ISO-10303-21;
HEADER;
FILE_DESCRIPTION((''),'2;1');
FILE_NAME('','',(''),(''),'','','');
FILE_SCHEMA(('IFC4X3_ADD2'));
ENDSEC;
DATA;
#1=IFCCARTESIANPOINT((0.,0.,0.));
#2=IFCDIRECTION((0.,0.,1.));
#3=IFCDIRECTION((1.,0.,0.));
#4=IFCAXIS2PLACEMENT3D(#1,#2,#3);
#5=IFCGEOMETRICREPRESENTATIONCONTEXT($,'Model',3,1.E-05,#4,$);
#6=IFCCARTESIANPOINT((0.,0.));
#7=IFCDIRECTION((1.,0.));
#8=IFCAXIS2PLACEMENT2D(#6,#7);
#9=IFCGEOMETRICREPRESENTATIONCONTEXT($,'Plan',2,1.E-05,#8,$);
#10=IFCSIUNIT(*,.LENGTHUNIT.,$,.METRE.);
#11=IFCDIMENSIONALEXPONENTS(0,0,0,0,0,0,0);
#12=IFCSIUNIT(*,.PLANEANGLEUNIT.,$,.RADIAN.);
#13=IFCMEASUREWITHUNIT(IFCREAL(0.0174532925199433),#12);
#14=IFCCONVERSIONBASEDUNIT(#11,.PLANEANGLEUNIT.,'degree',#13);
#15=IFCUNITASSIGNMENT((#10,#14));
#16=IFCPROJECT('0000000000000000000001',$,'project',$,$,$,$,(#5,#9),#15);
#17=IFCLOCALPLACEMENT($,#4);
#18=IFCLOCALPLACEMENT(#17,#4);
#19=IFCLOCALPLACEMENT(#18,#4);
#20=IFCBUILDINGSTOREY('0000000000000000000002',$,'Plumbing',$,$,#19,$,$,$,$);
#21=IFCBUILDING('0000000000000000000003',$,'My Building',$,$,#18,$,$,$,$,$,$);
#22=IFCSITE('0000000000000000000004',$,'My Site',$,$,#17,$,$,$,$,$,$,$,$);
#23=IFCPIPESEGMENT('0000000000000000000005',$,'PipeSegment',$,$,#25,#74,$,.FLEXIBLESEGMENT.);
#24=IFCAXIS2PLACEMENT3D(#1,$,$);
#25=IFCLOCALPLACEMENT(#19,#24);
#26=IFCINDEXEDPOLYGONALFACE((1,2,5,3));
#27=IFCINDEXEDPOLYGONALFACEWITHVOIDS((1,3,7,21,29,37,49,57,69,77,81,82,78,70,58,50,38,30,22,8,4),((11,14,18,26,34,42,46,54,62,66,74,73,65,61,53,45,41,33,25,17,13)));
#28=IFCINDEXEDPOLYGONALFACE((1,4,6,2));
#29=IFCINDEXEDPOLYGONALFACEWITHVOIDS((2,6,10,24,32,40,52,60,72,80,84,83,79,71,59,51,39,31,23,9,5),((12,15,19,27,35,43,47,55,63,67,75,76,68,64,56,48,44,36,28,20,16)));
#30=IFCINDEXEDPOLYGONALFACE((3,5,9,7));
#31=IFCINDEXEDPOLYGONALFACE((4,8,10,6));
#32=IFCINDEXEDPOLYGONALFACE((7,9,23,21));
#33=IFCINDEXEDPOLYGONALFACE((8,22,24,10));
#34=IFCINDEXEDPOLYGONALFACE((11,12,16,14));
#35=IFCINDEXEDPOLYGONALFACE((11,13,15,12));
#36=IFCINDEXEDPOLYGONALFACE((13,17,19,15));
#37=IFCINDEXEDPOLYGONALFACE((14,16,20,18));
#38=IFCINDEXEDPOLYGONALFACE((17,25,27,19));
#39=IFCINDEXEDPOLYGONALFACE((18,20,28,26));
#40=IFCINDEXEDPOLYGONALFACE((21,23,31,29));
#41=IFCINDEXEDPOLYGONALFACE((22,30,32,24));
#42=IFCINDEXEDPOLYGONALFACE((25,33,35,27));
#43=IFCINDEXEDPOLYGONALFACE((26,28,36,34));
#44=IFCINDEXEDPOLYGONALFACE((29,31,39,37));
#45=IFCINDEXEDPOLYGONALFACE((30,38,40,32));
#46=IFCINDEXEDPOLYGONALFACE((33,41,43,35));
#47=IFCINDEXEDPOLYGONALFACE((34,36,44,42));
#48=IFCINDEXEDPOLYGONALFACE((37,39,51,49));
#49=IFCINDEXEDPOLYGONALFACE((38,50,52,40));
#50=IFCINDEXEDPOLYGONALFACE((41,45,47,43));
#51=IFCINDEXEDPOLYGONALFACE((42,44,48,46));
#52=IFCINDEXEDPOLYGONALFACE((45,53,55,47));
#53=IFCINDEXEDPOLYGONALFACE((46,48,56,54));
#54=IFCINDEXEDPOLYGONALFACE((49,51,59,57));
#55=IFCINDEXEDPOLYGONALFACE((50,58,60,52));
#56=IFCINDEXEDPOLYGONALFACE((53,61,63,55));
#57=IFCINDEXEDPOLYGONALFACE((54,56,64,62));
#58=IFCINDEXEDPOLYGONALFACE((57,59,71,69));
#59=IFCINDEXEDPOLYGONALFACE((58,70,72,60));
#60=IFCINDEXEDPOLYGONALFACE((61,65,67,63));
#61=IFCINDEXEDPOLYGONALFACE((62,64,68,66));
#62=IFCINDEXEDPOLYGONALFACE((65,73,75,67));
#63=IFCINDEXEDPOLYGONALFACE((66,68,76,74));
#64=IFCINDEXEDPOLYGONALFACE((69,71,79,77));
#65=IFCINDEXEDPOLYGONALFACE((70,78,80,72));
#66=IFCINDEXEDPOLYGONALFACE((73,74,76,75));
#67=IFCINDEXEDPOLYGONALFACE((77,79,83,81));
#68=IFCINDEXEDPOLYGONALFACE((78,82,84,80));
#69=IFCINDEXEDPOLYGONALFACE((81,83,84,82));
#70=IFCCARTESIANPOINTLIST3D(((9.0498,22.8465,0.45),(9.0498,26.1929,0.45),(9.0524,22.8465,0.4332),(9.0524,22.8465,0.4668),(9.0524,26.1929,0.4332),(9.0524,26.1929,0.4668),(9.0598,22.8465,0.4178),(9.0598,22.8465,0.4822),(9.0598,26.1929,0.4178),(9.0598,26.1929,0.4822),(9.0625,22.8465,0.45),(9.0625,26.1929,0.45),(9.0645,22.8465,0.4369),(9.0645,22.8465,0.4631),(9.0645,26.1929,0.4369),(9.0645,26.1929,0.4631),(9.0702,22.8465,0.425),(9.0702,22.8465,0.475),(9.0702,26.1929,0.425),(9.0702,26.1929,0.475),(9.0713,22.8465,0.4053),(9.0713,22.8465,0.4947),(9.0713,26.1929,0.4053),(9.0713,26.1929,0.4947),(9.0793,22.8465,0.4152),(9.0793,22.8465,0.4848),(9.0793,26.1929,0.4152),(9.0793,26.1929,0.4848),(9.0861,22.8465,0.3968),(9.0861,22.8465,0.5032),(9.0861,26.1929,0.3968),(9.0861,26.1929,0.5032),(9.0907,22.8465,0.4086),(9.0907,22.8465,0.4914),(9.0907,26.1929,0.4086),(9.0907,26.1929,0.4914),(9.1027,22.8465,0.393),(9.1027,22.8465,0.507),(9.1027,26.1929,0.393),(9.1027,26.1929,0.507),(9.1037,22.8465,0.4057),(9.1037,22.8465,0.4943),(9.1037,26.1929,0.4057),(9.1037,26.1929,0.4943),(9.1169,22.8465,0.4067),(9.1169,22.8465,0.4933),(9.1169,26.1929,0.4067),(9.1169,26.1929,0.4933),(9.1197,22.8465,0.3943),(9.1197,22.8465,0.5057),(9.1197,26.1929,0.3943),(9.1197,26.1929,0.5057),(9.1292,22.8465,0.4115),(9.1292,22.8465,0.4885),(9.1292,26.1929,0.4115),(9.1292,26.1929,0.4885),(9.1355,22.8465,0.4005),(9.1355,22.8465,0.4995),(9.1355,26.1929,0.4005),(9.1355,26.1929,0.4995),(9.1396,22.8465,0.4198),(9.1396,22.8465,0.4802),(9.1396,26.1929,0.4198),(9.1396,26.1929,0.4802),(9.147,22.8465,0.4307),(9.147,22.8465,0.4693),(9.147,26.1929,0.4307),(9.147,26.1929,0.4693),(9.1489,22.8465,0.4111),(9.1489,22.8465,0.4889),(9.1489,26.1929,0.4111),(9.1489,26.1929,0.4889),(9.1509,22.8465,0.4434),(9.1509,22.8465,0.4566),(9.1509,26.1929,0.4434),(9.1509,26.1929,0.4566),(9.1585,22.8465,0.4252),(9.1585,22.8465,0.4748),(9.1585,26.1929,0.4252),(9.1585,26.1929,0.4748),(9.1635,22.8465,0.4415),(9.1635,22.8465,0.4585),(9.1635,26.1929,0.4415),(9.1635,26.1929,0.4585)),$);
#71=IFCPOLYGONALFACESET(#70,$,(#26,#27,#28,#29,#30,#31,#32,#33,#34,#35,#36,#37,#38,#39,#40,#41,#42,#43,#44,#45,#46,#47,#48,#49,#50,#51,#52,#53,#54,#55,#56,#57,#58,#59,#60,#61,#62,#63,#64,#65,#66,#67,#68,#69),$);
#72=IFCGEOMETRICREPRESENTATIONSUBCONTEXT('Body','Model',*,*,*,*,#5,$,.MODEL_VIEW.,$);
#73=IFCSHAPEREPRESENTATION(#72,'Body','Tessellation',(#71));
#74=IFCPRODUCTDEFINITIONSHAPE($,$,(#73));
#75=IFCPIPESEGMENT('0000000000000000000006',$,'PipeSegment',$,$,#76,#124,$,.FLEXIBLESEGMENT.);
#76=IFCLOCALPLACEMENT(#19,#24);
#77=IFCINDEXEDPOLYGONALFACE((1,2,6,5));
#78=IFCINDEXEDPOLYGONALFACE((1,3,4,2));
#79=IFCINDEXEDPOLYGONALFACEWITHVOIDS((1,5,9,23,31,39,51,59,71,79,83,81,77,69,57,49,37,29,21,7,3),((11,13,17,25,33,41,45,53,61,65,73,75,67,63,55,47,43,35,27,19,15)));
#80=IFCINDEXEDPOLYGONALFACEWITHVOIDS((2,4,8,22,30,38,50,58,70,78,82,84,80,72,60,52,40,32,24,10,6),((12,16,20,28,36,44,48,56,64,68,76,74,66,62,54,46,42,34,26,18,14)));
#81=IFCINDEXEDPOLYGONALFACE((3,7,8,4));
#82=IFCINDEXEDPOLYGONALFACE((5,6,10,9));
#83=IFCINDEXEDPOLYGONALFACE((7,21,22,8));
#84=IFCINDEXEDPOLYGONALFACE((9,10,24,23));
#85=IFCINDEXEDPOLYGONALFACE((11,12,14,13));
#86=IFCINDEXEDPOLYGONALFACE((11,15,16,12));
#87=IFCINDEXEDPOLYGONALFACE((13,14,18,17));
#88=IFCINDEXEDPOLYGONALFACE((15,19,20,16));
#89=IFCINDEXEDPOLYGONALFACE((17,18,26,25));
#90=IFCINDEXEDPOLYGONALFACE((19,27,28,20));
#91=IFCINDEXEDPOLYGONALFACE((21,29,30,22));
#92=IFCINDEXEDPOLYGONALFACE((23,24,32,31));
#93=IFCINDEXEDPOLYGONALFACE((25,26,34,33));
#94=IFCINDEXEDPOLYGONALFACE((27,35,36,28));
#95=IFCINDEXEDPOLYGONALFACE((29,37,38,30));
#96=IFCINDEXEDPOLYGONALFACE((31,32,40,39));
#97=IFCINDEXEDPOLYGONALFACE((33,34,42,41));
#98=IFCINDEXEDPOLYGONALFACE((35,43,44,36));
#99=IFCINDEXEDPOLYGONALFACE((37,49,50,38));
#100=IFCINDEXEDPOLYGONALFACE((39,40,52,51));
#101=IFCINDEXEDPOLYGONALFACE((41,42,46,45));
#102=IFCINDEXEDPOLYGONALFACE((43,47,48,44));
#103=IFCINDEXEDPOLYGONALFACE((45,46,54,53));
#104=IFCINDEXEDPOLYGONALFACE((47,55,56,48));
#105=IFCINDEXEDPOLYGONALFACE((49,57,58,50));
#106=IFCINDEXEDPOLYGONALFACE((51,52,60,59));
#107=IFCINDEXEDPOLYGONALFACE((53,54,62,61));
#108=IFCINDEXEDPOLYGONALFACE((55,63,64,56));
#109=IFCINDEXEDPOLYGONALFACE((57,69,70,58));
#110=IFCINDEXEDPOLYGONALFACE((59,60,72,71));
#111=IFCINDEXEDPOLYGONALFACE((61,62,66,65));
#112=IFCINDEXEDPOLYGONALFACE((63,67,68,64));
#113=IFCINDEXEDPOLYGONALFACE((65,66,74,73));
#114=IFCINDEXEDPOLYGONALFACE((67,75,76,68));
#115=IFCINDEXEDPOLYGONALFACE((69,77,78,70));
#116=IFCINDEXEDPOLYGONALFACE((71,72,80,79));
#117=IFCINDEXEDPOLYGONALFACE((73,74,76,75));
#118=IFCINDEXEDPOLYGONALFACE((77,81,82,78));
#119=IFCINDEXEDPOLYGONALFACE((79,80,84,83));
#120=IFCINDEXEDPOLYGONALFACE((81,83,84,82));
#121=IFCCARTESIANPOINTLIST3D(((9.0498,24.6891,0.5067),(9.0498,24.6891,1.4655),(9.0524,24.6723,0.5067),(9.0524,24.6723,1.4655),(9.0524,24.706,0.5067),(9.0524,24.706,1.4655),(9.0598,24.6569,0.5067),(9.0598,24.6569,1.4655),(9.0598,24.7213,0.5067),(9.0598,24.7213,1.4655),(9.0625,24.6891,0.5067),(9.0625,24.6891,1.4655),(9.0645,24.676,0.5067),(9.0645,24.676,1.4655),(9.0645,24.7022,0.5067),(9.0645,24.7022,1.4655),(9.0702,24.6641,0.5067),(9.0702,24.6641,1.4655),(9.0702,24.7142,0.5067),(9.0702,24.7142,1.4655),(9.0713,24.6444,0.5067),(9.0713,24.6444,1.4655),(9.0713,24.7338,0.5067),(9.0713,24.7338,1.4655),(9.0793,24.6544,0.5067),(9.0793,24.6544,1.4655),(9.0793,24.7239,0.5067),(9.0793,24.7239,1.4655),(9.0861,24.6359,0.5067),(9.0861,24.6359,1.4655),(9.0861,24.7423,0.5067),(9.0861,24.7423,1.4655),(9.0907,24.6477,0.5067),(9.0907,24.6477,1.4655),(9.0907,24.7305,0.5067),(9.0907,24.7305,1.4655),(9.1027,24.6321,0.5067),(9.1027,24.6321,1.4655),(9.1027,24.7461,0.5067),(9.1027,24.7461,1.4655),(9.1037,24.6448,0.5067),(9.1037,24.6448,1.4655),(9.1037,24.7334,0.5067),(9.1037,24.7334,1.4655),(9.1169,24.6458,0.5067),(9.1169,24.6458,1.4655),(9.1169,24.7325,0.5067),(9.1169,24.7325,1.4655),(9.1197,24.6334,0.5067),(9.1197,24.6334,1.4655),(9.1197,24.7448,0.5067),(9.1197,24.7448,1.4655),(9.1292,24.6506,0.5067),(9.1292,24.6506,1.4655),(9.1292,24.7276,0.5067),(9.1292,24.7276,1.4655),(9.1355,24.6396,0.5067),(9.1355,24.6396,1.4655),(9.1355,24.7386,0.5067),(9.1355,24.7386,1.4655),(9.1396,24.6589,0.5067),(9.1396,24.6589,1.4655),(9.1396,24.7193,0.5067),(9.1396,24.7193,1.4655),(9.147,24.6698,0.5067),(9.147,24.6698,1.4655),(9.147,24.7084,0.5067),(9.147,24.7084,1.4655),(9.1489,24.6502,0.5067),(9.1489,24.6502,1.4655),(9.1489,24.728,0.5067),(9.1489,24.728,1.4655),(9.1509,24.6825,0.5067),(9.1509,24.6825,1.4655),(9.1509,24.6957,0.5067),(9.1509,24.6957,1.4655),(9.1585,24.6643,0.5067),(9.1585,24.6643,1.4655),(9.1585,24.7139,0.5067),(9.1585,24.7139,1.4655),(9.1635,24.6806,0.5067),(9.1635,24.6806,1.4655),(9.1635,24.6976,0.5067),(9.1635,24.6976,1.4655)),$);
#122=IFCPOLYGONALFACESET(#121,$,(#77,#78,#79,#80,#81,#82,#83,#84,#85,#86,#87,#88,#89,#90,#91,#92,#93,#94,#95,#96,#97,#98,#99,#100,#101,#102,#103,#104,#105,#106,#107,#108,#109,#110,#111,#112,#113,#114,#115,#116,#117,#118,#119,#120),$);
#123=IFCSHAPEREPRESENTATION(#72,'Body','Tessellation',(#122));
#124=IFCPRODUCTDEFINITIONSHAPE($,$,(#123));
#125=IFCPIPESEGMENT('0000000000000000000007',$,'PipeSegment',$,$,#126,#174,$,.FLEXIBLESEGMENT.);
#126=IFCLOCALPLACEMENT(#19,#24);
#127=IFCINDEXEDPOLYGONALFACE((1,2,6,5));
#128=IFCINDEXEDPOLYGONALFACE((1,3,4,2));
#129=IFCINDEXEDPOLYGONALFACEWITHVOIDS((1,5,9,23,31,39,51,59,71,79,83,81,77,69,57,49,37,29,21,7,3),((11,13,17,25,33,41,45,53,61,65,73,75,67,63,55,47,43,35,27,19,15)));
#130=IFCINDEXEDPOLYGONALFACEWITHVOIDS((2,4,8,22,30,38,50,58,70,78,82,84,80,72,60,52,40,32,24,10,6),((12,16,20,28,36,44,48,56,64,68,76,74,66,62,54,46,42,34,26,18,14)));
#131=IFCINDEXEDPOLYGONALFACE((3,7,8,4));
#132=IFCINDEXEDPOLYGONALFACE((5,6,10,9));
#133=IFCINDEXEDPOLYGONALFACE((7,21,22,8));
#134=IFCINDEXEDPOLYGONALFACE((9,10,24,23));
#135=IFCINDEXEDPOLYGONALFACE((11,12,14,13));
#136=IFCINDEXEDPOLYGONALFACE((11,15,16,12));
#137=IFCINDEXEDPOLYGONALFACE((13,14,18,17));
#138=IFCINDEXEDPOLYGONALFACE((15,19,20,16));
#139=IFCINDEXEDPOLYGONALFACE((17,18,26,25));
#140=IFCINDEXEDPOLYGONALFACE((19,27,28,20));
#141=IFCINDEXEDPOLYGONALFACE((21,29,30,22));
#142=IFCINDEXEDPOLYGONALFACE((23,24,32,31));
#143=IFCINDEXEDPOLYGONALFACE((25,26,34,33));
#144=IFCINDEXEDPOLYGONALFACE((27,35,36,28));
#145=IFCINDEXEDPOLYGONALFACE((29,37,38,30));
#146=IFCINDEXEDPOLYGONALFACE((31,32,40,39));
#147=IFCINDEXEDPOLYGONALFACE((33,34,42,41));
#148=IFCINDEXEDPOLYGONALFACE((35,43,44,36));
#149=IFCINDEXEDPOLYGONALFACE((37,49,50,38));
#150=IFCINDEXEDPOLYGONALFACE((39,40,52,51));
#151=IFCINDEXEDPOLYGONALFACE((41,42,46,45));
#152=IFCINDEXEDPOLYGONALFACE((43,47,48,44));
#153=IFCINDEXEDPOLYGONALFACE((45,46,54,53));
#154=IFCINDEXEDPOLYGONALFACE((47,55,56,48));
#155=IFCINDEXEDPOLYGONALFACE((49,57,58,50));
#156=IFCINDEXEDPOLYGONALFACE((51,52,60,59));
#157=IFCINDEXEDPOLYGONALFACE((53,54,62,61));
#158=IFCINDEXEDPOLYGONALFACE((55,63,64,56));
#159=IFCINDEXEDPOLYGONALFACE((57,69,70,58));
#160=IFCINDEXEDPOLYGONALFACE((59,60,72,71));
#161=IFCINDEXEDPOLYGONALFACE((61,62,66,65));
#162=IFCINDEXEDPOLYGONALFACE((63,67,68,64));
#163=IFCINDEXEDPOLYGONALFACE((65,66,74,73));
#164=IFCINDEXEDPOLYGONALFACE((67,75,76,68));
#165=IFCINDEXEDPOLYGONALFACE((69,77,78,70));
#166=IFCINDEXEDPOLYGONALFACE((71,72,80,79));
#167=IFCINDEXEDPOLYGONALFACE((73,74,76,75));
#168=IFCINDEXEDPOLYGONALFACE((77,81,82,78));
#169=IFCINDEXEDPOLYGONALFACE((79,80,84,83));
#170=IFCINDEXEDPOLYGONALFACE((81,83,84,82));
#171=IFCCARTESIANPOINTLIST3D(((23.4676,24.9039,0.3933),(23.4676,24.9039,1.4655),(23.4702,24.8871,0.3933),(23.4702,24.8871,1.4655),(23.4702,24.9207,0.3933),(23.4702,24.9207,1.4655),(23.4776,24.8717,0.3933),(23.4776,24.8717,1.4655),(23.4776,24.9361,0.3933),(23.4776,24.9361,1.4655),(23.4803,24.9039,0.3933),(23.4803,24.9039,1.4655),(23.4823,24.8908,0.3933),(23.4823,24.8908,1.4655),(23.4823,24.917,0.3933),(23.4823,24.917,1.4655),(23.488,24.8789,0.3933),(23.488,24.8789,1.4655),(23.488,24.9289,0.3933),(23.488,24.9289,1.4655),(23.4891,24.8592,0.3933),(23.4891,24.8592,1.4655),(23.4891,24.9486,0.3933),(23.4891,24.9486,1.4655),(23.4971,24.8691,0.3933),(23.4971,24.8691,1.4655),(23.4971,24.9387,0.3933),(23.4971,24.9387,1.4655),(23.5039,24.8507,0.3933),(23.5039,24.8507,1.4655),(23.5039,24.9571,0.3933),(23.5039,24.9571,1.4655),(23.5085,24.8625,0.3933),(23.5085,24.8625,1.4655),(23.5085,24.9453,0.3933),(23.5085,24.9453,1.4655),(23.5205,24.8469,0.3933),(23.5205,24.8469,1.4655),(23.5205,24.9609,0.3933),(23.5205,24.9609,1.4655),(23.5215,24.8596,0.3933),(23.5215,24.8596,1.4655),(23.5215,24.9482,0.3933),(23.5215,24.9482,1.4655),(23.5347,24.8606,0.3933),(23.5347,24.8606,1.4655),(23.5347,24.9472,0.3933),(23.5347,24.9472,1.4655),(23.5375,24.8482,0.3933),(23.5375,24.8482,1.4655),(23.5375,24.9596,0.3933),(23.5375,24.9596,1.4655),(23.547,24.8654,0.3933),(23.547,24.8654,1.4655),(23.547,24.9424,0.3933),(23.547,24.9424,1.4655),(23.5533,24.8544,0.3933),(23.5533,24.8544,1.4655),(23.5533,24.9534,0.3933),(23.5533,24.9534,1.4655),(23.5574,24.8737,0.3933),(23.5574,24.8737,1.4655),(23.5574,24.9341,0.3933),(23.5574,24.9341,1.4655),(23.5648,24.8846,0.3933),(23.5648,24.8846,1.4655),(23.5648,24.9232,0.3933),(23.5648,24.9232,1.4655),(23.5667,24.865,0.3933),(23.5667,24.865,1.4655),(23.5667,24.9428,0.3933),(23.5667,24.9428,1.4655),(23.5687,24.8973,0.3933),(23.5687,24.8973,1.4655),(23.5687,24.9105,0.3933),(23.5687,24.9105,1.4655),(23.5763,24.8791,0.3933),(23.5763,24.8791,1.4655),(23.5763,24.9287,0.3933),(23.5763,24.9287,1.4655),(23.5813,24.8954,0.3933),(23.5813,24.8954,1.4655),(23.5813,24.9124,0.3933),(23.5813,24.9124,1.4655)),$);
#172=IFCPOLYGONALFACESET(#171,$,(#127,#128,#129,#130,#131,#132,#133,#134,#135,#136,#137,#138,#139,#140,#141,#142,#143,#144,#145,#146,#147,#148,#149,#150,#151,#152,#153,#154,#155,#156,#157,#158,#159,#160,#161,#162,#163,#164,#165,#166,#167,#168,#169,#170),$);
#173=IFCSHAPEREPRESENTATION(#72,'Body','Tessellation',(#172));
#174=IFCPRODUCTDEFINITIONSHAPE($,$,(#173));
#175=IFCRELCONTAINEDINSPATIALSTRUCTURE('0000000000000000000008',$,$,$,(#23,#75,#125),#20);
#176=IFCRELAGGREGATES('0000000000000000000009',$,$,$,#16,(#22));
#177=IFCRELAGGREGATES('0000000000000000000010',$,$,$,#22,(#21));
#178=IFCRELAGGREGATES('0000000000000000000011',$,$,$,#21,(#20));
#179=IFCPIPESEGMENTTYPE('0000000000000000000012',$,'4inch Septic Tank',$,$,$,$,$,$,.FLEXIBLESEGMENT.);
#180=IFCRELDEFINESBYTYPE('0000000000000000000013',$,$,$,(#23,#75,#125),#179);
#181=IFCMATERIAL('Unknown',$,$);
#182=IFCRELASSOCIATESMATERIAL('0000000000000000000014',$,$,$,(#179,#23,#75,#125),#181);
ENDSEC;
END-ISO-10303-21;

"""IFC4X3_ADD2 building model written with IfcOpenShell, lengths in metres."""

from ifc_helpers import new_model, entity, si_unit, converted_unit, frame, origin_with_axes, origin_2d_with_axis, place, context, subcontext, project, spatial, hollow_circle, extrude, material, material_profile, profile_set, profile_usage, type_object, element, save


model = new_model("IFC4X3_ADD2")

# Units and contexts
model_context = context("Model", 3, precision=1e-05, world=origin_with_axes())
plan_context = context("Plan", 2, precision=1e-05, world=origin_2d_with_axis())
body_context = subcontext(model_context, "Body", "Model", "MODEL_VIEW")
ifc_project = project(units=[si_unit("LENGTHUNIT", "METRE"), converted_unit("PLANEANGLEUNIT", "degree", entity("IfcReal", 0.0174532925199433), si_unit("PLANEANGLEUNIT", "RADIAN"), dimensions=[0, 0, 0, 0, 0, 0, 0])], contexts=[model_context, plan_context])

# Site, building, storey
site_placement = place(None, origin_with_axes())
site = spatial("IfcSite", under=ifc_project, at=site_placement, Name="My Site")
building_placement = place(site_placement, origin_with_axes())
building = spatial("IfcBuilding", under=site, at=building_placement, Name="My Building")
storey_placement = place(building_placement, origin_with_axes())
storey = spatial("IfcBuildingStorey", under=building, at=storey_placement, Name="Plumbing")

# Pipe segments
ifc_material_1 = material(Name="Unknown")
ifc_material_profile_1 = material_profile(ifc_material_1, hollow_circle(Radius=0.0571, WallThickness=0.0127))
ifc_profile_set_1 = profile_set([ifc_material_profile_1], Name="blackwater")
ifc_material_profile_2 = material_profile(ifc_material_1, hollow_circle(Radius=0.0571, WallThickness=0.0127))
ifc_profile_set_2 = profile_set([ifc_material_profile_2], Name="blackwater")
pipe_segment_type_1 = type_object("IfcPipeSegmentType", Name="4inch Septic Tank", PredefinedType="FLEXIBLESEGMENT", material=ifc_profile_set_2)
ifc_profile_usage_1 = profile_usage(ifc_profile_set_1, cardinal=5)
pipe_segment_1_placement = place(storey_placement, frame((9.107, 26.1929, 0.45), z_axis=(0.0, -1.0, 0.0), x_axis=(-1.0, 0.0, -0.000001)))
element("IfcPipeSegment", 1, at=pipe_segment_1_placement, inside=storey, type_object=pipe_segment_type_1, material=ifc_profile_usage_1, Name="PipeSegment", PredefinedType="FLEXIBLESEGMENT", context=body_context, shape_type="SweptSolid", body=[
    extrude(hollow_circle(Radius=0.0571, WallThickness=0.0127), origin_with_axes(), (0.0, 0.0, 1.0), 3.3464),
])
ifc_profile_usage_2 = profile_usage(ifc_profile_set_1, cardinal=5)
pipe_segment_2_placement = place(storey_placement, frame((9.107, 24.6891, 0.5067), z_axis=(0.0, 0.0, 1.0), x_axis=(-1.0, -0.000001, 0.0)))
element("IfcPipeSegment", 2, at=pipe_segment_2_placement, inside=storey, type_object=pipe_segment_type_1, material=ifc_profile_usage_2, Name="PipeSegment", PredefinedType="FLEXIBLESEGMENT", context=body_context, shape_type="SweptSolid", body=[
    extrude(hollow_circle(Radius=0.0571, WallThickness=0.0127), origin_with_axes(), (0.0, 0.0, 1.0), 0.9588),
])
ifc_profile_usage_3 = profile_usage(ifc_profile_set_1, cardinal=5)
pipe_segment_3_placement = place(storey_placement, frame((23.5248, 24.9039, 0.3933), z_axis=(0.0, 0.0, 1.0), x_axis=(-1.0, -0.000001, 0.0)))
element("IfcPipeSegment", 3, at=pipe_segment_3_placement, inside=storey, type_object=pipe_segment_type_1, material=ifc_profile_usage_3, Name="PipeSegment", PredefinedType="FLEXIBLESEGMENT", context=body_context, shape_type="SweptSolid", body=[
    extrude(hollow_circle(Radius=0.0571, WallThickness=0.0127), origin_with_axes(), (0.0, 0.0, 1.0), 1.0722),
])

save(model, "model.ifc")
